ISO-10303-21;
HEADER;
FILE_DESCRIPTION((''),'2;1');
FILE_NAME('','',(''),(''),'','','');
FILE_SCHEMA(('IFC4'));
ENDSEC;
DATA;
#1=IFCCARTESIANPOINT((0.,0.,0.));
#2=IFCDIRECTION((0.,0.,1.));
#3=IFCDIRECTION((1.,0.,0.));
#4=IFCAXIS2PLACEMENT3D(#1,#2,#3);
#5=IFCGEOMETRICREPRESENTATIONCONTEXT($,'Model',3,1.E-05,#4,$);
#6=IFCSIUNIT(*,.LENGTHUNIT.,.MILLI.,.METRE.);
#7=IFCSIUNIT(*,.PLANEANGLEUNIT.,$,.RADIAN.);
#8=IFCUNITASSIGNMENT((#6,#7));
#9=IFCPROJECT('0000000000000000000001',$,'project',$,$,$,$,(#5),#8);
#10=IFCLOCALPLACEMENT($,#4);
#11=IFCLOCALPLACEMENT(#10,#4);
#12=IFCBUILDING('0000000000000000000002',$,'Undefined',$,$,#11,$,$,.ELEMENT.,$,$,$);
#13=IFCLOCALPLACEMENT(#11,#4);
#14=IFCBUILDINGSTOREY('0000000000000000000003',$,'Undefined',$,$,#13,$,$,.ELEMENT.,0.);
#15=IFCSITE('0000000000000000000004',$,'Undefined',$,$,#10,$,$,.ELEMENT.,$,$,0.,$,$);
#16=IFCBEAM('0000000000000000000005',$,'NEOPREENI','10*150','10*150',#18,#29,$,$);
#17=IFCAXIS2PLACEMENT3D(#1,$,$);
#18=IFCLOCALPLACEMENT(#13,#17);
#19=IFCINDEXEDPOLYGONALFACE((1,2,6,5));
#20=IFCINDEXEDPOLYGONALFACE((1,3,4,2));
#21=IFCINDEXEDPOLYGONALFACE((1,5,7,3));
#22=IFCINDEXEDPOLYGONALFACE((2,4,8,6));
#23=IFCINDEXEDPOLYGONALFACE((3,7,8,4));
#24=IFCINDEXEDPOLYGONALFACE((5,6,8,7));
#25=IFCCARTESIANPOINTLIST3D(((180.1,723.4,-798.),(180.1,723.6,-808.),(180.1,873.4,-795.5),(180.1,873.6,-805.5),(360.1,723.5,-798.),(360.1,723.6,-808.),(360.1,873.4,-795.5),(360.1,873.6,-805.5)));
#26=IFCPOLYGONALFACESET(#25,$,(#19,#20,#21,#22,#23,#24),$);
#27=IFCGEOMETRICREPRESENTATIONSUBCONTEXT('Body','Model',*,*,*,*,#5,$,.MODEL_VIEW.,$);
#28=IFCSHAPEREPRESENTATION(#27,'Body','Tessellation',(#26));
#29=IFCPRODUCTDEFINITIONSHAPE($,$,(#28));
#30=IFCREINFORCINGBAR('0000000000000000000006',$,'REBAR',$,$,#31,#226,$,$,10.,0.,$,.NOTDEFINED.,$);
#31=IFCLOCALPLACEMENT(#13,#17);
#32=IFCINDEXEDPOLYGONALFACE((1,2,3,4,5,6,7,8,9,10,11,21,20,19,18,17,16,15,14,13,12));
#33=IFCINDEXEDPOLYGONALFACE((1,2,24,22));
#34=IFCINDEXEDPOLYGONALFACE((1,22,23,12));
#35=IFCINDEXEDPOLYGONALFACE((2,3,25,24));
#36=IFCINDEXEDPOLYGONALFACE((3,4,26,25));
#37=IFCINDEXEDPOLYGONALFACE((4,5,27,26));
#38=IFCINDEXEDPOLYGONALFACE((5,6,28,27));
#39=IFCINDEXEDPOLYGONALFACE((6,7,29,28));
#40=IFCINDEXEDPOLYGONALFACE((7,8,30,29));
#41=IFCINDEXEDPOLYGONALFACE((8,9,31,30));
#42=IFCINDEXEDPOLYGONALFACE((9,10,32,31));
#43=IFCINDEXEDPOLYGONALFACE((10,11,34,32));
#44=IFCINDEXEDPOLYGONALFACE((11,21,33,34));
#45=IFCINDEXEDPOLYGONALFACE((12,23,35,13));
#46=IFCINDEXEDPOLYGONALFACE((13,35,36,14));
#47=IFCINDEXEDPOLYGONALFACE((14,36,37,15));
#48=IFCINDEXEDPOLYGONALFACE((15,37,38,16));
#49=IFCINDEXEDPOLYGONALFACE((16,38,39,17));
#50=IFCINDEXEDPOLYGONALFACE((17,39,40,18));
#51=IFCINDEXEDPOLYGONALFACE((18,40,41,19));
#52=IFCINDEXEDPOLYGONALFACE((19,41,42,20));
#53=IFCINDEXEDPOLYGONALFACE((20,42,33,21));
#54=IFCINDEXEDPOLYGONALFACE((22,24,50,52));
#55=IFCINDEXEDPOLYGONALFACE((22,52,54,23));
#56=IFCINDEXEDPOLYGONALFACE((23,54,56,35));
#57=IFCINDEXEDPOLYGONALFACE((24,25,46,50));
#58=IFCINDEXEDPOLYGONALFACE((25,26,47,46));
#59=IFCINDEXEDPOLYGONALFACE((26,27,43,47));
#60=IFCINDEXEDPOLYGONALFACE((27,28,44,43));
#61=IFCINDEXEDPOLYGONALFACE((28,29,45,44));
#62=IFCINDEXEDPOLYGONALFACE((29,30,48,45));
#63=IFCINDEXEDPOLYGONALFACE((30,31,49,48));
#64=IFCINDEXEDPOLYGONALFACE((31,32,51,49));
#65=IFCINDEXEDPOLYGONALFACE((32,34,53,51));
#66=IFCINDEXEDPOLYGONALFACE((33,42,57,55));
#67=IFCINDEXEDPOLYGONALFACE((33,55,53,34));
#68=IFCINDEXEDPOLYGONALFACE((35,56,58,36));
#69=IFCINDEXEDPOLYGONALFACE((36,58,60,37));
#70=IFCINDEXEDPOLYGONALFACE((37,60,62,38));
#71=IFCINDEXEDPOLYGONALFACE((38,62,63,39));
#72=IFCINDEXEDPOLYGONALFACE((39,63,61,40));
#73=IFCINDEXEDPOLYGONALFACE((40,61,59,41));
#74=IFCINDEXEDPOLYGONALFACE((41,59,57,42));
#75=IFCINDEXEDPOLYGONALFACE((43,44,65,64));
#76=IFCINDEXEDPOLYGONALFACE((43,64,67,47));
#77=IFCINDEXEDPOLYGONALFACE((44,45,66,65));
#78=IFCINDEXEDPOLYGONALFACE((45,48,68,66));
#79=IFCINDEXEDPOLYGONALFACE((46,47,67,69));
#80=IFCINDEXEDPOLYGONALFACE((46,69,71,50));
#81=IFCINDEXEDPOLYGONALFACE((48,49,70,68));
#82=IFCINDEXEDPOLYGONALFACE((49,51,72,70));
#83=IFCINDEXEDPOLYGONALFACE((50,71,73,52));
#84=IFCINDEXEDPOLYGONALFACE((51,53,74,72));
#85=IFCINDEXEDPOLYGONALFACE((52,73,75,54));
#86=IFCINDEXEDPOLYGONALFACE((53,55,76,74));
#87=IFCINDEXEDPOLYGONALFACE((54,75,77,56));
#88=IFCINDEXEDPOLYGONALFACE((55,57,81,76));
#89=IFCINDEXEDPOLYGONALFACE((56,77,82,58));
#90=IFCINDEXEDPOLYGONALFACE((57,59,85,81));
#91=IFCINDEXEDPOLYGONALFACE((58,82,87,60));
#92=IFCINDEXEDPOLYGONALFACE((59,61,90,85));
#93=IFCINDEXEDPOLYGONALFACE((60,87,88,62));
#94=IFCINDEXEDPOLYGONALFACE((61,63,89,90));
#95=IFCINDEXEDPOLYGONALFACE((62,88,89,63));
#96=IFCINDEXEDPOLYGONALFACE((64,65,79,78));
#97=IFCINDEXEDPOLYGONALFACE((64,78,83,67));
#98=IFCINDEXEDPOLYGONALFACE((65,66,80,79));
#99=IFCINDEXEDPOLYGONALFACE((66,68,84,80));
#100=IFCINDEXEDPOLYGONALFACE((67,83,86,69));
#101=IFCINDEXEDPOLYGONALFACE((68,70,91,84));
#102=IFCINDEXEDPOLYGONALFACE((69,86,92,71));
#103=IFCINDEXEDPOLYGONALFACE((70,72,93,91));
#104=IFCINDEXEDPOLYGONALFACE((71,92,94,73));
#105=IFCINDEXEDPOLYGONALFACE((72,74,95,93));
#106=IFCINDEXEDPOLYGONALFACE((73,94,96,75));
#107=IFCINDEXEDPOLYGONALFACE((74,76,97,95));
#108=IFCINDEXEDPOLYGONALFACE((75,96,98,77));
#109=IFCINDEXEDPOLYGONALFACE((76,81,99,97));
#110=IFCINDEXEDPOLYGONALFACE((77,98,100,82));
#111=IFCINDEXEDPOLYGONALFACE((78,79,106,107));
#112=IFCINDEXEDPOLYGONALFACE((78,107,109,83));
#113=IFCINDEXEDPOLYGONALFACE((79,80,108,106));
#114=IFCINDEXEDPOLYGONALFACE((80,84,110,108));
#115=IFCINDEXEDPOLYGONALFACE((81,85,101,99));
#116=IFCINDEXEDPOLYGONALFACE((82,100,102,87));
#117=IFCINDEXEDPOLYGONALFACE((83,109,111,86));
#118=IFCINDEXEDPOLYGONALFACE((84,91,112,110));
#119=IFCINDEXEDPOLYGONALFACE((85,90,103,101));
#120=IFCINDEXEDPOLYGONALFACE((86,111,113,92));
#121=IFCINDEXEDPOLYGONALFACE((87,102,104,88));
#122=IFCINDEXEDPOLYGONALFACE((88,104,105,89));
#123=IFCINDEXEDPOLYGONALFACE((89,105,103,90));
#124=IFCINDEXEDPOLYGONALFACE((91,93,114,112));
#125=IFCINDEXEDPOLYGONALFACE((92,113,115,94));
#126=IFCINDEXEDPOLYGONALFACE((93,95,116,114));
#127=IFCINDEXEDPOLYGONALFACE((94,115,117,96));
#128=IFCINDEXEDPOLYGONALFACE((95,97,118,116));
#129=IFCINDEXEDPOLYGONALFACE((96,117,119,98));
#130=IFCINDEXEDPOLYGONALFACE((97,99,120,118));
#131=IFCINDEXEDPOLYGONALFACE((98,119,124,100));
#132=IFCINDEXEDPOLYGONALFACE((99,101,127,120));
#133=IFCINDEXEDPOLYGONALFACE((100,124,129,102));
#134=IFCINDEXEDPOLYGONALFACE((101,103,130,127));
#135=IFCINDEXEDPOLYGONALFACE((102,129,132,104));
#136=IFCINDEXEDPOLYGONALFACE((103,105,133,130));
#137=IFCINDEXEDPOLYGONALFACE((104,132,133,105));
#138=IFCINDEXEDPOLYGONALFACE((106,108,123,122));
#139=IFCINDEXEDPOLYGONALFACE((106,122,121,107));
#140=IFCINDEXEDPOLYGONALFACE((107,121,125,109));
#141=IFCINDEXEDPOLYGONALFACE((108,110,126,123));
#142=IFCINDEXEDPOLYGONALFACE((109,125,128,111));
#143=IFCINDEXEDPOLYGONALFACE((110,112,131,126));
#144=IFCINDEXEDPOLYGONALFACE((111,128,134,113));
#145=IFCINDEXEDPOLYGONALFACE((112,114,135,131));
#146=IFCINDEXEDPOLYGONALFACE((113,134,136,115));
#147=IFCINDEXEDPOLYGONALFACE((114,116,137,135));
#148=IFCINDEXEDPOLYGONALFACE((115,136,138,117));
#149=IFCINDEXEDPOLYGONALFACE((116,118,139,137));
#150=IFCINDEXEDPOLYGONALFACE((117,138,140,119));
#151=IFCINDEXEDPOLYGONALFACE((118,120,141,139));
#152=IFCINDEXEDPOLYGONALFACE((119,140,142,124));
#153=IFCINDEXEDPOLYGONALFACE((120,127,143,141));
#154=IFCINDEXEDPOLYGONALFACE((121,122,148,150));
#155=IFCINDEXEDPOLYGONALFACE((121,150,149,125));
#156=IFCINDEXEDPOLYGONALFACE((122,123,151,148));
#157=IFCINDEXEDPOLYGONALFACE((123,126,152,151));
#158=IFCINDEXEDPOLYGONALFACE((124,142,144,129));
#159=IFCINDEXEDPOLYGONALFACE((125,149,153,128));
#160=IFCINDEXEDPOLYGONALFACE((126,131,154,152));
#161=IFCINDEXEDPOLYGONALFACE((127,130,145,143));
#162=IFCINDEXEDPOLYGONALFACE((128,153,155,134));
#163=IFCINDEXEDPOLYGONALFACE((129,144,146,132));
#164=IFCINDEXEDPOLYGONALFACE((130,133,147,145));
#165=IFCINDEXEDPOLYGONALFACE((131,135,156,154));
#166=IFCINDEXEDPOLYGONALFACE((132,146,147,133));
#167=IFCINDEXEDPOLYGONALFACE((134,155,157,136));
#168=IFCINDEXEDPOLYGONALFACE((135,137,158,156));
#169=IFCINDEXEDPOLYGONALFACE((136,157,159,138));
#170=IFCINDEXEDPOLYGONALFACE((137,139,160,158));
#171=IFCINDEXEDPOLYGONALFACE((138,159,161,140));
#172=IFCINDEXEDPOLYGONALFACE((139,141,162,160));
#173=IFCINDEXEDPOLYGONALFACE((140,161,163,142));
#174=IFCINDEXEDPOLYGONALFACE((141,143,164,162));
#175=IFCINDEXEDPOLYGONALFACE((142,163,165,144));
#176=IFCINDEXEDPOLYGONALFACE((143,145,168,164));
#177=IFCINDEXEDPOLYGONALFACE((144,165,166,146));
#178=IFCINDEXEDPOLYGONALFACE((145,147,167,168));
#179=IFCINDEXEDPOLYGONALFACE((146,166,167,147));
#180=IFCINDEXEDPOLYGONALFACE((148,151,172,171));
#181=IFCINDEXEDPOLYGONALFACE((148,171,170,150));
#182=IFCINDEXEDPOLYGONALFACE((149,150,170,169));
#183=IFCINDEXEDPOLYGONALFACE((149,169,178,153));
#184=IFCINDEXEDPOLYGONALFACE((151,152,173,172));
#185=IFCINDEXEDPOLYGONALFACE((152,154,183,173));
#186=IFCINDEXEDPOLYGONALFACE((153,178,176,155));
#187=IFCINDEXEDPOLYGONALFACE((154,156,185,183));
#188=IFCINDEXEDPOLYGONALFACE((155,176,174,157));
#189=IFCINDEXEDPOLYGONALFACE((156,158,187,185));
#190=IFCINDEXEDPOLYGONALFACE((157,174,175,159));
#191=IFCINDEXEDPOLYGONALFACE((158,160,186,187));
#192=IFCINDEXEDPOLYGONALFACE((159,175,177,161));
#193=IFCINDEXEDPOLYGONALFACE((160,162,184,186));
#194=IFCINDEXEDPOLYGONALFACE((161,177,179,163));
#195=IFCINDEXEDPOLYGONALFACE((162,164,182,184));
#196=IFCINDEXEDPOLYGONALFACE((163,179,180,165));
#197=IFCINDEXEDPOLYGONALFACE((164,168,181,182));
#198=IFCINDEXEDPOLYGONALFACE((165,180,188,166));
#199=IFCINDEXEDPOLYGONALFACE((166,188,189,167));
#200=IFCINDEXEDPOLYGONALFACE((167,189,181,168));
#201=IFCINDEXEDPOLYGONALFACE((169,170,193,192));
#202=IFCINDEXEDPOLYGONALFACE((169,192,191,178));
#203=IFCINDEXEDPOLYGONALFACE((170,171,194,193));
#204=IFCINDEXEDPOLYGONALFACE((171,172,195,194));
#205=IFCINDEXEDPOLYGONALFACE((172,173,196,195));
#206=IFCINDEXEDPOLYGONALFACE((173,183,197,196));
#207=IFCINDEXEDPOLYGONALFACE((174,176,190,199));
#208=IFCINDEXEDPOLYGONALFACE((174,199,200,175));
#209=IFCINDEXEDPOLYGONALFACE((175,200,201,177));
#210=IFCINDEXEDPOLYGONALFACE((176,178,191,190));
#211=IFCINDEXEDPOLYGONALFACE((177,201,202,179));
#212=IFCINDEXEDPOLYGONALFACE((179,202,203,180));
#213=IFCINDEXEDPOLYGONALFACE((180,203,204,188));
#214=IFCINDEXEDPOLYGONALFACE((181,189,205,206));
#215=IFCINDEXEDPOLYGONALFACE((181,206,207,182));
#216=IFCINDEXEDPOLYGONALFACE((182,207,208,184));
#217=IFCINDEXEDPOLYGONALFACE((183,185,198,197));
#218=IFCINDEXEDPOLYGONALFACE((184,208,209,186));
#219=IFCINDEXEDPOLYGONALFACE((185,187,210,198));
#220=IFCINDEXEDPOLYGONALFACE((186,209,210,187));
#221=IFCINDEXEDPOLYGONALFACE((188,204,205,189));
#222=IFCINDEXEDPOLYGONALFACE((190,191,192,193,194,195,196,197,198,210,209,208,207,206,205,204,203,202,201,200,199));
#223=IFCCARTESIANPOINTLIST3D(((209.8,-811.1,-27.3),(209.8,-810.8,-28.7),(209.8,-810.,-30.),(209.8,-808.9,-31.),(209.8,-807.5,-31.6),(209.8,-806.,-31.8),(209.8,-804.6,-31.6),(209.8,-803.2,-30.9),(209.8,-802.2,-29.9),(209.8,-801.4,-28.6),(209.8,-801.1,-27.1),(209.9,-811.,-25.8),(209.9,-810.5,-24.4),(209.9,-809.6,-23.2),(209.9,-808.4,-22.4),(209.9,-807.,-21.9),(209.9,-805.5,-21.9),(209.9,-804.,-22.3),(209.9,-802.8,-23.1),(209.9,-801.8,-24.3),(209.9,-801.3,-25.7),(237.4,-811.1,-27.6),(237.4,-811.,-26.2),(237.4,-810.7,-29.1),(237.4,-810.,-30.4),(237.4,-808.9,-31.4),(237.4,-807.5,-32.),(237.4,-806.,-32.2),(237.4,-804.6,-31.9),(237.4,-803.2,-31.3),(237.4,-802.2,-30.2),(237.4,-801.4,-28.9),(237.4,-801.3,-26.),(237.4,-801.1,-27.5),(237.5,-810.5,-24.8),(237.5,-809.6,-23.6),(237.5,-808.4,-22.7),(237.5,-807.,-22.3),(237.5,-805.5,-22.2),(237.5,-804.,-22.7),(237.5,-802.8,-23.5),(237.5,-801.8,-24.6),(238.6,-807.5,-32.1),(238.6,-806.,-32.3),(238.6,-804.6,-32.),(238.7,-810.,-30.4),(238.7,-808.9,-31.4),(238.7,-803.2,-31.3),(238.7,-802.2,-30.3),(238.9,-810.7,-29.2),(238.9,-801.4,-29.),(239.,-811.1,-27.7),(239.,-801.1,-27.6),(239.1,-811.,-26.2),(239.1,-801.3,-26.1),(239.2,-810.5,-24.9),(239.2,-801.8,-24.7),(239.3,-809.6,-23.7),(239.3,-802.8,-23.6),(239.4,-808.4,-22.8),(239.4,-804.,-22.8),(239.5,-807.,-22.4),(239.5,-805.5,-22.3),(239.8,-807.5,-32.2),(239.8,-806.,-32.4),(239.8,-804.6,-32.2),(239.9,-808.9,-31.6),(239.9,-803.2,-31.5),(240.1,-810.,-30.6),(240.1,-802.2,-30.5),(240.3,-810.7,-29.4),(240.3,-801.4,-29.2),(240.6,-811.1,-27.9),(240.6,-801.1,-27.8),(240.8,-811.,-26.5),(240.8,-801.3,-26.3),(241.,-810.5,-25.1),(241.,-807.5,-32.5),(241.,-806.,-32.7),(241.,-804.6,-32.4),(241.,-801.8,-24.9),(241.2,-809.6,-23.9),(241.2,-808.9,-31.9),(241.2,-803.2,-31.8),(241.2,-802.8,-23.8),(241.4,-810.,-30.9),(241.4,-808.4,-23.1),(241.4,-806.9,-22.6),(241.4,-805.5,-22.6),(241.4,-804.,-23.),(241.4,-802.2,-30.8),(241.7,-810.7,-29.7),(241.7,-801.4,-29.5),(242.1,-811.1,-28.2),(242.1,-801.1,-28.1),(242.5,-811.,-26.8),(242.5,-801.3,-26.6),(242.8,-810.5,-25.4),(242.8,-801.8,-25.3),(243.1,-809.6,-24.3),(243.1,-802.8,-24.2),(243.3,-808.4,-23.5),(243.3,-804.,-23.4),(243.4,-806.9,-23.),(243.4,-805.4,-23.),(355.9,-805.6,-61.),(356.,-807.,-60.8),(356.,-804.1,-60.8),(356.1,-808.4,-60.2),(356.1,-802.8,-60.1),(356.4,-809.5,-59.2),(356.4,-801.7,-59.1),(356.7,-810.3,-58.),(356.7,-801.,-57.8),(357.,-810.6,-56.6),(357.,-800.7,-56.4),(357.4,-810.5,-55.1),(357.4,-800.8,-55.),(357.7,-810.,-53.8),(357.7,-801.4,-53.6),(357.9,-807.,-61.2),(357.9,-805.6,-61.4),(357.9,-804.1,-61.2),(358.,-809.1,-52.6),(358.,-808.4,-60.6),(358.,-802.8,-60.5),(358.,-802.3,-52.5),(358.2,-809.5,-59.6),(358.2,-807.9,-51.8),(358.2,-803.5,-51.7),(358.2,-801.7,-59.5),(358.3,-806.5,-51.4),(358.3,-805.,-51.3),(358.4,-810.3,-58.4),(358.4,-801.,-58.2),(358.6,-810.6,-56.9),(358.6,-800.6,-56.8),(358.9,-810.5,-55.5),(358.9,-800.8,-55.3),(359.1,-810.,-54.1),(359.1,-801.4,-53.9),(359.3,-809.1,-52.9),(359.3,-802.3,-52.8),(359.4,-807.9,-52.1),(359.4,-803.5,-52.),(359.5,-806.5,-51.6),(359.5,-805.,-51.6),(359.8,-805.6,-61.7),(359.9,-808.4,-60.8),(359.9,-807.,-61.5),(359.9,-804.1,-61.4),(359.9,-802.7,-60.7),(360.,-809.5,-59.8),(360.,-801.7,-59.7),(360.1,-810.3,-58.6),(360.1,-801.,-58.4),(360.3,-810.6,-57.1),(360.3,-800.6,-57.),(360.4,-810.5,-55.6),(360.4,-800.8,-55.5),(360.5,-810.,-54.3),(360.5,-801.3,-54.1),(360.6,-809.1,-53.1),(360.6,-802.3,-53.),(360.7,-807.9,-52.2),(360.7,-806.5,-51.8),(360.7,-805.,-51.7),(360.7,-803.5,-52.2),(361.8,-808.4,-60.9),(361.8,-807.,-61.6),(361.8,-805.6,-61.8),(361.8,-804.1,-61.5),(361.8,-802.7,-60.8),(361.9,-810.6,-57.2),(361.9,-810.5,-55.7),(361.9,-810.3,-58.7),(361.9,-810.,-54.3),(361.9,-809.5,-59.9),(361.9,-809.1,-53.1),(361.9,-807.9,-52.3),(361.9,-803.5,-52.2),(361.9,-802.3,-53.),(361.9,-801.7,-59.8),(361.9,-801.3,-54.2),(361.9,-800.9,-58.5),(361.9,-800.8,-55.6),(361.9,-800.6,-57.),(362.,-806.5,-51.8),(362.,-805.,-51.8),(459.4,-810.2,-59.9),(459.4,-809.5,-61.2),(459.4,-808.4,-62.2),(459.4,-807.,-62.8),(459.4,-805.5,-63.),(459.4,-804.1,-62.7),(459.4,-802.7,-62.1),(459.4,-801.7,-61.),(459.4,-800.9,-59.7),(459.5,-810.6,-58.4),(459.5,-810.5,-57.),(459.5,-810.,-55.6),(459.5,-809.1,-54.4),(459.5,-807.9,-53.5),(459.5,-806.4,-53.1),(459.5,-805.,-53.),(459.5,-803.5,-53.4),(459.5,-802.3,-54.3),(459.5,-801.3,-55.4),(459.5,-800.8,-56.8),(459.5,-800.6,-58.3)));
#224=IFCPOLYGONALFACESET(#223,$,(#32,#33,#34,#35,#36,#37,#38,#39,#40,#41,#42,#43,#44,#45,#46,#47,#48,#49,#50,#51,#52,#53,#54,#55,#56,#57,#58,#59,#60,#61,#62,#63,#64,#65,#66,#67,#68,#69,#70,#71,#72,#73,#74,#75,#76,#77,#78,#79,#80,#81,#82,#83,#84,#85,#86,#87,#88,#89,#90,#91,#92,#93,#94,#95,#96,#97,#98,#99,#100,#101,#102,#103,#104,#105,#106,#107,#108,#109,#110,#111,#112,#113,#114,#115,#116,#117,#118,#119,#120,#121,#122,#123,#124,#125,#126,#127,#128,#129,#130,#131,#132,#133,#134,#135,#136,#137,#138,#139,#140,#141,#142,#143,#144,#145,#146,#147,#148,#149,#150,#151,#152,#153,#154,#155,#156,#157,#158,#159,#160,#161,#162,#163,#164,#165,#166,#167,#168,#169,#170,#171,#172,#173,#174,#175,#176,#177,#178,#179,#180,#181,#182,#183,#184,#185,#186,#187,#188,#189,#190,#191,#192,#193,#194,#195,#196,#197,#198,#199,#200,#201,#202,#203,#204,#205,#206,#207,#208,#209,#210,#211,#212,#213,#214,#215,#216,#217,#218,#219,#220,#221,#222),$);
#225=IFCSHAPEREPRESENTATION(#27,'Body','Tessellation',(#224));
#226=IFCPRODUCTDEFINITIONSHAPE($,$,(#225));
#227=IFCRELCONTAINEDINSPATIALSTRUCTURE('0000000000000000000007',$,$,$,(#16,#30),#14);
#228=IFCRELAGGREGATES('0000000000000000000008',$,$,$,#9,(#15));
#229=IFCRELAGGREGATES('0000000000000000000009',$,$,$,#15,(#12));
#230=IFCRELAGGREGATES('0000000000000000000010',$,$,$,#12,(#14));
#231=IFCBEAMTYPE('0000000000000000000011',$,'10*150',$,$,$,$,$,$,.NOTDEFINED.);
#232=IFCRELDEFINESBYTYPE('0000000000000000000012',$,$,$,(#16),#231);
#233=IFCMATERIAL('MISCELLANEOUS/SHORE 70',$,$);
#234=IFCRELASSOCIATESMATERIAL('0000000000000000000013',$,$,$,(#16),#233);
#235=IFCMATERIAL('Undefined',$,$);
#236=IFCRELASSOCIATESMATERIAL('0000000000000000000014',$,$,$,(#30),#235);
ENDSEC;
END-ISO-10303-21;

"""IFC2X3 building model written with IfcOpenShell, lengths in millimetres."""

from ifc_helpers import new_model, entity, si_unit, frame, origin_with_axes, origin_2d_with_axis, place, context, subcontext, project, spatial, rectangle, extrude, source, transform, mapped, material, type_object, element, save


model = new_model("IFC2X3")

# Units and contexts
model_context = context("Model", 3, precision=1e-05, world=origin_with_axes())
body_context = subcontext(model_context, "Body", "Model", "MODEL_VIEW")
ifc_project = project(units=[si_unit("LENGTHUNIT", "METRE", prefix="MILLI"), si_unit("PLANEANGLEUNIT", "RADIAN")], contexts=[model_context])

# Site, building, storey
site_placement = place(None, origin_with_axes())
site = spatial("IfcSite", under=ifc_project, at=site_placement, Name="Undefined", CompositionType="ELEMENT", RefElevation=0.0)
building_placement = place(site_placement, origin_with_axes())
building = spatial("IfcBuilding", under=site, at=building_placement, Name="Undefined", CompositionType="ELEMENT")
storey_placement = place(building_placement, origin_with_axes())
storey = spatial("IfcBuildingStorey", under=building, at=storey_placement, Name="Undefined", CompositionType="ELEMENT", Elevation=0.0)

# Beam
ifc_material_1 = material(Name="MISCELLANEOUS/SHORE 70")
beam_type_1 = type_object("IfcBeamType", Name="10*150", PredefinedType="NOTDEFINED")
beam_1_placement = place(storey_placement, frame((180.1, 798.5, -801.8), z_axis=(-0.000005, -0.016723, 0.99986), x_axis=(1.0, 0.000015, 0.000005)))
element("IfcBeam", 1, at=beam_1_placement, inside=storey, type_object=beam_type_1, material=ifc_material_1, Name="NEOPREENI", Description="10*150", ObjectType="10*150", context=body_context, shape_type="SweptSolid", body=[
    extrude(rectangle(XDim=150.0, YDim=10.0, at=origin_2d_with_axis()), frame((180.0, 0.0, 0.0), z_axis=(-1.0, 0.0, 0.0), x_axis=(0.0, -1.0, 0.0)), (0.0, 0.0, 1.0), 180.0),
])

# Reinforcing bar
ifc_material_2 = material(Name="Undefined")
vector_1 = entity("IfcVector", entity("IfcDirection", [0.973841, 0.0, -0.22723]), 1.0)
shared_shape_1 = source(origin_with_axes(), body_context, "Body", "AdvancedSweptSolid", [
    entity("IfcSweptDiskSolid", entity("IfcCompositeCurve", [entity("IfcCompositeCurveSegment", "CONTINUOUS", True, entity("IfcTrimmedCurve", entity("IfcLine", entity("IfcCartesianPoint", [0.0, 0.0, 0.0]), vector_1), [entity("IfcParameterValue", 0.0)], [entity("IfcParameterValue", 27.582469)], True, "PARAMETER")), entity("IfcCompositeCurveSegment", "CONTINUOUS", True, entity("IfcTrimmedCurve", entity("IfcCircle", entity("IfcAxis2Placement3D", entity("IfcCartesianPoint", [31.6, 0.0, 14.2]), entity("IfcDirection", [0.0, -1.0, 0.0]), entity("IfcDirection", [-0.22723, 0.0, -0.973841])), 21.0), [entity("IfcParameterValue", 0.0)], [entity("IfcParameterValue", 0.229232)], True, "PARAMETER")), entity("IfcCompositeCurveSegment", "CONTINUOUS", True, entity("IfcTrimmedCurve", entity("IfcLine", entity("IfcCartesianPoint", [31.6, 0.0, -6.8]), entity("IfcVector", entity("IfcDirection", [1.0, 0.0, 0.0]), 1.0)), [entity("IfcParameterValue", 0.0)], [entity("IfcParameterValue", 118.388313)], True, "PARAMETER")), entity("IfcCompositeCurveSegment", "CONTINUOUS", True, entity("IfcTrimmedCurve", entity("IfcCircle", entity("IfcAxis2Placement3D", entity("IfcCartesianPoint", [150.0, 0.0, -27.8]), entity("IfcDirection", [0.0, 1.0, 0.0]), entity("IfcDirection", [0.0, 0.0, 1.0])), 21.0), [entity("IfcParameterValue", 0.0)], [entity("IfcParameterValue", 0.229232)], True, "PARAMETER")), entity("IfcCompositeCurveSegment", "DISCONTINUOUS", True, entity("IfcTrimmedCurve", entity("IfcLine", entity("IfcCartesianPoint", [154.8, 0.0, -7.4]), vector_1), [entity("IfcParameterValue", 0.0)], [entity("IfcParameterValue", 97.582469)], True, "PARAMETER"))], False), 5.0, None, 0.0, 244.0),
])
reinforcing_bar_1_placement = place(storey_placement, frame((239.8, -806.1, -27.2), z_axis=(-0.239469, 0.016234, -0.970768), x_axis=(0.970904, 0.003979, -0.239436)))
element("IfcReinforcingBar", 2, at=reinforcing_bar_1_placement, inside=storey, material=ifc_material_2, Name="REBAR", BarRole="NOTDEFINED", CrossSectionArea=0.0, NominalDiameter=10.0, context=body_context, shape_type="MappedRepresentation", body=[
    mapped(shared_shape_1, transform((-29.2, 0.0, 6.8))),
])

save(model, "model.ifc")
